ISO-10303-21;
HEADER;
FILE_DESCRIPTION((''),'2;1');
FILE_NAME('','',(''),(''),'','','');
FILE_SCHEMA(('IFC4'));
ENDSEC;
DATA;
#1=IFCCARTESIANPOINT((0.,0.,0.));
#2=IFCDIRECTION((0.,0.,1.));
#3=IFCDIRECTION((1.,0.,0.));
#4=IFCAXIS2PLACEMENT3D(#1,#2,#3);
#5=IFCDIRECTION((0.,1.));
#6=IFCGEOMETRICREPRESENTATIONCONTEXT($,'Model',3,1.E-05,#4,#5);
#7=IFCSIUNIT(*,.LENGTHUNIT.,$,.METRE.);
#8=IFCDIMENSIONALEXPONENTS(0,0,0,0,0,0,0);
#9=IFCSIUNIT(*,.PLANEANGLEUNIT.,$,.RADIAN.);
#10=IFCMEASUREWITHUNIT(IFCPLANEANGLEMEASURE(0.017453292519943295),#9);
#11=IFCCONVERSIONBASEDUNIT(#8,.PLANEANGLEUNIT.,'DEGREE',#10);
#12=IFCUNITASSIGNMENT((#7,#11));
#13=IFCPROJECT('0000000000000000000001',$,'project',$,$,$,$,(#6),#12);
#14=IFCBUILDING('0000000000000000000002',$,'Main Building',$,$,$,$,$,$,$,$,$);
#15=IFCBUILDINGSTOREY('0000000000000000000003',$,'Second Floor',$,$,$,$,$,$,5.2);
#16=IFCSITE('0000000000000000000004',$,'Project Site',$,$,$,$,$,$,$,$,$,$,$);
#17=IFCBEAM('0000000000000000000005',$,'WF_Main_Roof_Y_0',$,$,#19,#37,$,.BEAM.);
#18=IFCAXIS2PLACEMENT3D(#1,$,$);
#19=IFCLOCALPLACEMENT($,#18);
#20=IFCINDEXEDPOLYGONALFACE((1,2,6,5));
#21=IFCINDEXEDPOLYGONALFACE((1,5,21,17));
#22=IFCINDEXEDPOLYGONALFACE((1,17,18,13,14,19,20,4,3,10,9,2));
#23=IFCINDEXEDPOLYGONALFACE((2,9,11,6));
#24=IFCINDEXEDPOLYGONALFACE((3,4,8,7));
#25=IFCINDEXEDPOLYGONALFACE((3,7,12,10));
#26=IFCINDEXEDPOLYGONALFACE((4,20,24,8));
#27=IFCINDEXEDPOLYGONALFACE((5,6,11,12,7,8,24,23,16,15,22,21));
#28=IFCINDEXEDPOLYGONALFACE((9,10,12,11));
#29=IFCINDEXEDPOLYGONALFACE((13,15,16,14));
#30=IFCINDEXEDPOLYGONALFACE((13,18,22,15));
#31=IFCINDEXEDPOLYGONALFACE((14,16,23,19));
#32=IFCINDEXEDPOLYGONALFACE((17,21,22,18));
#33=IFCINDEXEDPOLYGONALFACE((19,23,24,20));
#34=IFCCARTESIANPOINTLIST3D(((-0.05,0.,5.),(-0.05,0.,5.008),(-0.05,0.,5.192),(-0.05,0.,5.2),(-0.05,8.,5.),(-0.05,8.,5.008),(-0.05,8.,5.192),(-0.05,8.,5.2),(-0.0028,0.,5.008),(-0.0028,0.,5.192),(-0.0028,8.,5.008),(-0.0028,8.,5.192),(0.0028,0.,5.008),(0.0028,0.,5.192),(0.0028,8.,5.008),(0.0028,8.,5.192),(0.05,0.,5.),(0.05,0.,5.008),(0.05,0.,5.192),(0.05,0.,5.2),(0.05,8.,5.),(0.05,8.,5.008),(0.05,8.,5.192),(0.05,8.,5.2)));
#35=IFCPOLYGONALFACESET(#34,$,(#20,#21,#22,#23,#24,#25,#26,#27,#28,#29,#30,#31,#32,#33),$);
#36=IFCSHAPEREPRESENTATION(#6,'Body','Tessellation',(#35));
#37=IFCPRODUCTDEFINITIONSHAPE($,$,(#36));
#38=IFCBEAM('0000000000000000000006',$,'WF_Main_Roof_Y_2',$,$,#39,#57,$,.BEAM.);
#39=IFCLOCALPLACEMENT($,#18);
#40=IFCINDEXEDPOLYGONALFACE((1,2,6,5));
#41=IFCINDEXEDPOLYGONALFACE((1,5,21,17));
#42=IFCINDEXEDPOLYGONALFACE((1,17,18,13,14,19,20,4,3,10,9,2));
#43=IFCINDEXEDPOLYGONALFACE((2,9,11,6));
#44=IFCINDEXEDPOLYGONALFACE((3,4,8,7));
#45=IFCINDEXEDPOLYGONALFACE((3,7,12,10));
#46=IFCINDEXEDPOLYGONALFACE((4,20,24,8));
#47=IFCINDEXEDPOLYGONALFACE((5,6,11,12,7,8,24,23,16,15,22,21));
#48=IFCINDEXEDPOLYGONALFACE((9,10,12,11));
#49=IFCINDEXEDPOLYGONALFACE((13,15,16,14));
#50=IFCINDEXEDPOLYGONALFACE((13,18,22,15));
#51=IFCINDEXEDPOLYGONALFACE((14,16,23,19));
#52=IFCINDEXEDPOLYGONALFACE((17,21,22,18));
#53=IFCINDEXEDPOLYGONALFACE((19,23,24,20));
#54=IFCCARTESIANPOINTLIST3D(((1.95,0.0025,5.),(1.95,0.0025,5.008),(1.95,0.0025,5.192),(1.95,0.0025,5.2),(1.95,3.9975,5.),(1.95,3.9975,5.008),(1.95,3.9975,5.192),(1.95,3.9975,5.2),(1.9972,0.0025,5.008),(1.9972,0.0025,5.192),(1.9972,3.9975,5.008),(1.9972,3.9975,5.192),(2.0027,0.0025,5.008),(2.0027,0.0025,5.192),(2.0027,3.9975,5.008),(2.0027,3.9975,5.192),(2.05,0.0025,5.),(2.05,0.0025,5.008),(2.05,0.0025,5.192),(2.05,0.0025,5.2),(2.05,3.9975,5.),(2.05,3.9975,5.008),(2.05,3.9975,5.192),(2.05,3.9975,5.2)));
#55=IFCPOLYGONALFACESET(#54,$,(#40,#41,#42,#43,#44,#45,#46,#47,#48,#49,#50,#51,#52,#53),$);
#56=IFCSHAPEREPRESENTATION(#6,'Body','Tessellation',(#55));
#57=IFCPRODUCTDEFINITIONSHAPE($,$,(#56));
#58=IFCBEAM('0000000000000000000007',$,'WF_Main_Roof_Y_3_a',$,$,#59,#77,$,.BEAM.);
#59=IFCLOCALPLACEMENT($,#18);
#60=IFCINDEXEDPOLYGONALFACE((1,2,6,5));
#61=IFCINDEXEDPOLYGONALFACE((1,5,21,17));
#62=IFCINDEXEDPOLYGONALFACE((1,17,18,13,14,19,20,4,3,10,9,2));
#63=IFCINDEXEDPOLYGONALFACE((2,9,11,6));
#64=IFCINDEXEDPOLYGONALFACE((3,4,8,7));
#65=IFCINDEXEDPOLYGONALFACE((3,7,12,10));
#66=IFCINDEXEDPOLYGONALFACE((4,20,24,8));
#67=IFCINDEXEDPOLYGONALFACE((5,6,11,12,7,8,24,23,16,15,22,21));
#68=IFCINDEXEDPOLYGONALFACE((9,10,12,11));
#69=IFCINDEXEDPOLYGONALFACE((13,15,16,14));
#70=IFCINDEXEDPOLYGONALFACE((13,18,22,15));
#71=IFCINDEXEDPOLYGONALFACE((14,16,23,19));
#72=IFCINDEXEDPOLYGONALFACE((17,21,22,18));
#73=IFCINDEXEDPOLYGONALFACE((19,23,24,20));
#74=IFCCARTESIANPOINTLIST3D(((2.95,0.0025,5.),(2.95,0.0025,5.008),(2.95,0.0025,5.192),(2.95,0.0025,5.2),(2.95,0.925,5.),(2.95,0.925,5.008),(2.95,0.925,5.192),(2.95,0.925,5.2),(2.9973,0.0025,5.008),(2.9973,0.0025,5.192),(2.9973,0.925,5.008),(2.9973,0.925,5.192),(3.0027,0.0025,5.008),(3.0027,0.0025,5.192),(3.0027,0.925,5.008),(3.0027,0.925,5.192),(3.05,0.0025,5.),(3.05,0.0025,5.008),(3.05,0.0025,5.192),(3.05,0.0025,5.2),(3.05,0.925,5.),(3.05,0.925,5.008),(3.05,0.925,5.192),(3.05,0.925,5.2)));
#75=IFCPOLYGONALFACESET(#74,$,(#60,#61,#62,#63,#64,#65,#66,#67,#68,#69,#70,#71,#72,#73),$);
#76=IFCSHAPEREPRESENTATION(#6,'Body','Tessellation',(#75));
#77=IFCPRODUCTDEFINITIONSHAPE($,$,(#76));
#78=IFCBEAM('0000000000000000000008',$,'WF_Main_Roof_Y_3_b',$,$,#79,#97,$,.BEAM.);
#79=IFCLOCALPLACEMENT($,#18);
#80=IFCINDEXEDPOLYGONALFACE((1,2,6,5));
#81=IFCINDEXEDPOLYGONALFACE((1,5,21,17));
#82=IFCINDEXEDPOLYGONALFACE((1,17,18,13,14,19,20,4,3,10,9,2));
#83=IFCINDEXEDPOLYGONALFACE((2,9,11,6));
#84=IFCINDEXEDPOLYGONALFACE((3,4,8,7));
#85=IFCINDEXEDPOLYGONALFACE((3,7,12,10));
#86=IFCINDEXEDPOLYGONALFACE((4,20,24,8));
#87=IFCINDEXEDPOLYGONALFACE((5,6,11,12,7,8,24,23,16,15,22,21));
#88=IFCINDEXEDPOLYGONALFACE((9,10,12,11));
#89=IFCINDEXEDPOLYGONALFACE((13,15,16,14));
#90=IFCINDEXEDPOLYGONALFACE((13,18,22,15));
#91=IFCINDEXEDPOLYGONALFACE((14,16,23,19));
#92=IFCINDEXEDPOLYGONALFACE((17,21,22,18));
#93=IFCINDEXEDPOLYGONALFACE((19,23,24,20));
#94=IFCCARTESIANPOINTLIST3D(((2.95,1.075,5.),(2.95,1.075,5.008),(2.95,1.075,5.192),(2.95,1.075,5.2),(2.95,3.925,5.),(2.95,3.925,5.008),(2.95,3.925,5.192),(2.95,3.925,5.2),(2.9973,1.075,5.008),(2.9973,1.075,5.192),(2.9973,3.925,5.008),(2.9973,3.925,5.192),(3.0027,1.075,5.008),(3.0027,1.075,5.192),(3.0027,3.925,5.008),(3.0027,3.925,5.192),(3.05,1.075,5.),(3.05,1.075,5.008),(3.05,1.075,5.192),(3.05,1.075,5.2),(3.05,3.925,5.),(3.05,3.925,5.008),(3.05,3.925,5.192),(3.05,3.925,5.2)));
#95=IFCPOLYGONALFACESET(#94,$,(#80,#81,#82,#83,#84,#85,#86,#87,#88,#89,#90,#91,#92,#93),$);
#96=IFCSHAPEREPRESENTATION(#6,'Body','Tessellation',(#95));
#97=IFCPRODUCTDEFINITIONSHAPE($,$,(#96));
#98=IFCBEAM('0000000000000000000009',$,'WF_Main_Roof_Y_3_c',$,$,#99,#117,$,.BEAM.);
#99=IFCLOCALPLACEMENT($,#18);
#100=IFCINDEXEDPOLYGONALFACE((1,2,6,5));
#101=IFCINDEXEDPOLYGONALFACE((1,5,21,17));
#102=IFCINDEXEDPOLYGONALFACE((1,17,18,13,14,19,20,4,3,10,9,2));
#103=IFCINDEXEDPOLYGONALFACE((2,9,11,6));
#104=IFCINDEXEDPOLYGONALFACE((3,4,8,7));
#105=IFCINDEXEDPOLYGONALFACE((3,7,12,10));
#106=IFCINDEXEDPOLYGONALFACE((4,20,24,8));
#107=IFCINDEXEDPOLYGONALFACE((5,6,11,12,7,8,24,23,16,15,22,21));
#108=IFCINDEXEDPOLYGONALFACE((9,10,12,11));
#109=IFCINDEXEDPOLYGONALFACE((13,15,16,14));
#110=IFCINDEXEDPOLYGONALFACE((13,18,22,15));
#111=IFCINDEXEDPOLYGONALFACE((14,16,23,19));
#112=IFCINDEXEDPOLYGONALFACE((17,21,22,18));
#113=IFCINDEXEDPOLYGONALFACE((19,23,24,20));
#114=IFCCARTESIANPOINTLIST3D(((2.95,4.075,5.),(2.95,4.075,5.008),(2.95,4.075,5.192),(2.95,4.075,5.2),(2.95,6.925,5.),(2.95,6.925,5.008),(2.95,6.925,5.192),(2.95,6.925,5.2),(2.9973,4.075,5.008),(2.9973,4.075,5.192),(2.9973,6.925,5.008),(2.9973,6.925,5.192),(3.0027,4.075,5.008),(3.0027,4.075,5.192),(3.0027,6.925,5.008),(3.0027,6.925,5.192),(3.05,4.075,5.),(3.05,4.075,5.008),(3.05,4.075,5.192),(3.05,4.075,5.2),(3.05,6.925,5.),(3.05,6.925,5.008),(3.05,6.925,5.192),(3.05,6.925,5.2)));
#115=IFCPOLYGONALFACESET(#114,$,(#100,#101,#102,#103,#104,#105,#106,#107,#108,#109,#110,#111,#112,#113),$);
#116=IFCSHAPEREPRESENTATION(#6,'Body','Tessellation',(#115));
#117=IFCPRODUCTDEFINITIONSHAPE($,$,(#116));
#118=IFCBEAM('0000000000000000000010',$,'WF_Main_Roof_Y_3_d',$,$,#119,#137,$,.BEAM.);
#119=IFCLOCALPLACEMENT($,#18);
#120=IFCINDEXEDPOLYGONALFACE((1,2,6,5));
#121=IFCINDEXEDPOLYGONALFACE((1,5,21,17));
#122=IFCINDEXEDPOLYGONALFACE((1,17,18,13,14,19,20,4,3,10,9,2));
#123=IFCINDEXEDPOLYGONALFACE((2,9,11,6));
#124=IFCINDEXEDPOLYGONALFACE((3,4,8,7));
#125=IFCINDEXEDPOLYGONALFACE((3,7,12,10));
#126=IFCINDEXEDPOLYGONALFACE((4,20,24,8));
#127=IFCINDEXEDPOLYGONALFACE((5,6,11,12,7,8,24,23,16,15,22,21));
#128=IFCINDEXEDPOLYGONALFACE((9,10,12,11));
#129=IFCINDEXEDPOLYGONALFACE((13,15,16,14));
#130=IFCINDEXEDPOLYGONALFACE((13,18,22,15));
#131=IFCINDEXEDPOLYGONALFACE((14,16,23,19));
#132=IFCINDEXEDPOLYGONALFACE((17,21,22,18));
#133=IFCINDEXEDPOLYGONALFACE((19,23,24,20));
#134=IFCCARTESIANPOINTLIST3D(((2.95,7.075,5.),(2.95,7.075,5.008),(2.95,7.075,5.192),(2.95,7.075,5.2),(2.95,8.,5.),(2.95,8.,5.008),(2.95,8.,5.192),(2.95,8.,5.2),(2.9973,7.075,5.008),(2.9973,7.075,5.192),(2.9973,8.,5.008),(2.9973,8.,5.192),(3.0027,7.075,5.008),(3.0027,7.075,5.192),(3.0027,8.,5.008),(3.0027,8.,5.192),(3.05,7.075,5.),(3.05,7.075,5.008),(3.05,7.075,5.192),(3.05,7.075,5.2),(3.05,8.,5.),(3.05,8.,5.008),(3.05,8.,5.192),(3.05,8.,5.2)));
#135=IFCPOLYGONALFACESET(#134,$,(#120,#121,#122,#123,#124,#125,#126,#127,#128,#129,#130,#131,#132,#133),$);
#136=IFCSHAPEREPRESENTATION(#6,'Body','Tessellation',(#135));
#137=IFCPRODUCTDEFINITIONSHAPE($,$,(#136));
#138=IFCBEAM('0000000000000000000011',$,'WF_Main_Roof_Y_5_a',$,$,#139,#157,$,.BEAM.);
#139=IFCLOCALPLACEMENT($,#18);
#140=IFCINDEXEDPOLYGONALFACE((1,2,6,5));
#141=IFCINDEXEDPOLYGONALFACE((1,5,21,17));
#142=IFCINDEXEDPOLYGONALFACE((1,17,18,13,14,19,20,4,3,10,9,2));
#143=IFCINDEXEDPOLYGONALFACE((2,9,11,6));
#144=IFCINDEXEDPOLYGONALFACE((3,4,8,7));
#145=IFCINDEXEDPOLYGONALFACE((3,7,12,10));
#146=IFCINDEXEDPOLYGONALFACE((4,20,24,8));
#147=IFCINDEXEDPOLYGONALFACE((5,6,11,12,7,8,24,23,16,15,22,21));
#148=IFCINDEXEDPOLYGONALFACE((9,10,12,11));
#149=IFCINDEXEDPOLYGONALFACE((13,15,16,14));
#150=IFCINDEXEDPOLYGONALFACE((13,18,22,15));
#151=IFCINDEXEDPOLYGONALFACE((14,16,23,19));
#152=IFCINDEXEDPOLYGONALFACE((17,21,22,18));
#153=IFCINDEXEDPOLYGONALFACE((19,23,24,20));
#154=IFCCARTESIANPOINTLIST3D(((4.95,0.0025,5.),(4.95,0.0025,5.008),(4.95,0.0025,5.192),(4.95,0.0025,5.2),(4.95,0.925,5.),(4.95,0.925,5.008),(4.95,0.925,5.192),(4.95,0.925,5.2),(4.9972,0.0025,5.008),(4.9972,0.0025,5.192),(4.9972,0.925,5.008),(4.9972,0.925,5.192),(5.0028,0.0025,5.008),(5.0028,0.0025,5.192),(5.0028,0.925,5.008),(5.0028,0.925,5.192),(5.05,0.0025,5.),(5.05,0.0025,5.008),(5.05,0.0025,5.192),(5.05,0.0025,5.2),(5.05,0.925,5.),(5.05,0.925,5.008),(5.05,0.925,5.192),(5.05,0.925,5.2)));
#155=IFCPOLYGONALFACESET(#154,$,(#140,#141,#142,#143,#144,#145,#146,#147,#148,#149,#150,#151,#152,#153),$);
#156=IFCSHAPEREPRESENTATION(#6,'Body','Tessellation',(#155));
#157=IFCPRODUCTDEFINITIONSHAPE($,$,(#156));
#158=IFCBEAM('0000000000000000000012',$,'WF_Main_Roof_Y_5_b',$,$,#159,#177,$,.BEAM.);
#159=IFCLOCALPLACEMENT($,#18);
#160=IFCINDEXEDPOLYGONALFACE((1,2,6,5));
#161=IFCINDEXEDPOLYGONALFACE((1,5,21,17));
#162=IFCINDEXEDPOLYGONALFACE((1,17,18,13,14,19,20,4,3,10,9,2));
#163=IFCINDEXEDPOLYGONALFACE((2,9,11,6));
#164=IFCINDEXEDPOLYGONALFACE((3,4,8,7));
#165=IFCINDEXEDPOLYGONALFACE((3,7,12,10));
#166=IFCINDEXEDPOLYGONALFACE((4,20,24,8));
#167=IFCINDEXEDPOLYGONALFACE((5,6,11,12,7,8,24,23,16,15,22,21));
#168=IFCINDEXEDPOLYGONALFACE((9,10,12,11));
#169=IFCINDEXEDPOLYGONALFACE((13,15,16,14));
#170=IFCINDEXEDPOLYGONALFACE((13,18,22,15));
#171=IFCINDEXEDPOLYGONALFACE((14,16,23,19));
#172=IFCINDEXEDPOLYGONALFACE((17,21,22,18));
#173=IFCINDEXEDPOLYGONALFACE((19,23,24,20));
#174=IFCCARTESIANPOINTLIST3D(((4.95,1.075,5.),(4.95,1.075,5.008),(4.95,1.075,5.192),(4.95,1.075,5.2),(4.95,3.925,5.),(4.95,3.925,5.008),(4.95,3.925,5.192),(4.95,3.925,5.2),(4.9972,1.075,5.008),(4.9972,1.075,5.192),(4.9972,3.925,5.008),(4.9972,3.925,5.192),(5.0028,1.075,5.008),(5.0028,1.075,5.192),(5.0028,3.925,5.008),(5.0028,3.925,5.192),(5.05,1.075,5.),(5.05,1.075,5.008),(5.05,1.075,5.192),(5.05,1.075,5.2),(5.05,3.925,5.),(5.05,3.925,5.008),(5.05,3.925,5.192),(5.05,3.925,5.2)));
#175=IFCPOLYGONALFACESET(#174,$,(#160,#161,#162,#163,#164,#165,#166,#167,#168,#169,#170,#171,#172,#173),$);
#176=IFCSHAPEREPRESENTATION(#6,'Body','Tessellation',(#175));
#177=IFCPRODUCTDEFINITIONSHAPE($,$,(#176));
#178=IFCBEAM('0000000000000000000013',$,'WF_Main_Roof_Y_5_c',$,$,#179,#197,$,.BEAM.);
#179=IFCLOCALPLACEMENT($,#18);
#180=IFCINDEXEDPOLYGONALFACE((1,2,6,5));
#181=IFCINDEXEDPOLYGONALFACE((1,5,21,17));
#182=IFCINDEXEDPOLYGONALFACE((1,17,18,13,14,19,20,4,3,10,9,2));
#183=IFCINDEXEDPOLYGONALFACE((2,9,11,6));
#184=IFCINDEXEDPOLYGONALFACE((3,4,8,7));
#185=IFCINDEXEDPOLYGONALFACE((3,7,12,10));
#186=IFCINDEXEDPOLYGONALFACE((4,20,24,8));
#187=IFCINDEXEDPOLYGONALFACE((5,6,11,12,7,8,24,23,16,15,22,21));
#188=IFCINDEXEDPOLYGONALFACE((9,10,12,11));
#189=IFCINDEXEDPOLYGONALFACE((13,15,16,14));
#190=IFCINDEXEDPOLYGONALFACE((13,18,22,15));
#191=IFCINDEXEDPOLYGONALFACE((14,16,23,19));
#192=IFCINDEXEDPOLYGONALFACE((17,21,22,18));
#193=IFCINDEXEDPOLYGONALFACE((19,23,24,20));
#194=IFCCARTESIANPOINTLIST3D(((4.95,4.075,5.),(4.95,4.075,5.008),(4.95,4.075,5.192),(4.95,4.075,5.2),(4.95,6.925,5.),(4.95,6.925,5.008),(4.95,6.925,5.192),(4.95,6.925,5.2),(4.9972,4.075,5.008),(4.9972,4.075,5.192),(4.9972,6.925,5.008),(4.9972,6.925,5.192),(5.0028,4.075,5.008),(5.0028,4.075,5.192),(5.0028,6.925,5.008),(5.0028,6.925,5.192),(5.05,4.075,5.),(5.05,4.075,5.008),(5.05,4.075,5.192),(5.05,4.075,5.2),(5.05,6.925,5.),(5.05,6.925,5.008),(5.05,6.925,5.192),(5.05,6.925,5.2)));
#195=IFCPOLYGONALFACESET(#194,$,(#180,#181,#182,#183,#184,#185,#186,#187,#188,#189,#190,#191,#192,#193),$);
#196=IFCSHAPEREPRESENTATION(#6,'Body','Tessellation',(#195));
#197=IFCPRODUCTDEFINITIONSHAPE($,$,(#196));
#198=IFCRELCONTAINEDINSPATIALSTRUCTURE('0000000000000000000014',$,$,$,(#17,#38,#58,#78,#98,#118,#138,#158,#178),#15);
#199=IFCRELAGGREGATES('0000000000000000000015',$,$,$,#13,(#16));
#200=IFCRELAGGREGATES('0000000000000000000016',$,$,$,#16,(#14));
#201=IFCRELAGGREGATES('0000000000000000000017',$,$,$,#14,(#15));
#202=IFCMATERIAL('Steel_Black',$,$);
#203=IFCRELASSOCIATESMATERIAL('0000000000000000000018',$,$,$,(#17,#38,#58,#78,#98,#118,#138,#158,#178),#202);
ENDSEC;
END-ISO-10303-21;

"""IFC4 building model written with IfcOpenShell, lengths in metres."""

from ifc_helpers import new_model, entity, si_unit, converted_unit, direction, frame, frame_2d, origin_with_axes, place, context, project, spatial, i_section, extrude, material, element, save


model = new_model("IFC4")

# Units and contexts
model_context = context("Model", 3, precision=1e-05, world=origin_with_axes(), true_north=direction((0.0, 1.0)))
ifc_project = project(units=[si_unit("LENGTHUNIT", "METRE"), converted_unit("PLANEANGLEUNIT", "DEGREE", entity("IfcPlaneAngleMeasure", 0.017453292519943295), si_unit("PLANEANGLEUNIT", "RADIAN"), dimensions=[0, 0, 0, 0, 0, 0, 0])], contexts=[model_context])

# Site, building, storey
site = spatial("IfcSite", under=ifc_project, Name="Project Site")
building = spatial("IfcBuilding", under=site, Name="Main Building")
storey = spatial("IfcBuildingStorey", under=building, Name="Second Floor", Elevation=5.2)

# Beams
ifc_material = material(Name="Steel_Black")
beam_1_placement = place(None, frame((0.0, 0.0, 5.0), z_axis=(0.0, 0.0, 1.0), x_axis=(0.0, 1.0, 0.0)))
element("IfcBeam", 1, at=beam_1_placement, inside=storey, material=ifc_material, Name="WF_Main_Roof_Y_0", PredefinedType="BEAM", context=model_context, shape_type="SweptSolid", body=[
    extrude(i_section(OverallWidth=0.1, OverallDepth=0.2, WebThickness=0.0055, FlangeThickness=0.008, at=frame_2d((0.0, 0.1))), frame((0.0, 0.0, 0.0), z_axis=(1.0, 0.0, 0.0), x_axis=(0.0, 1.0, 0.0)), (0.0, 0.0, 1.0), 8.0),
])
beam_2_placement = place(None, frame((2.0, 0.0025, 5.0), z_axis=(0.0, 0.0, 1.0), x_axis=(0.0, 1.0, 0.0)))
element("IfcBeam", 2, at=beam_2_placement, inside=storey, material=ifc_material, Name="WF_Main_Roof_Y_2", PredefinedType="BEAM", context=model_context, shape_type="SweptSolid", body=[
    extrude(i_section(OverallWidth=0.1, OverallDepth=0.2, WebThickness=0.0055, FlangeThickness=0.008, at=frame_2d((0.0, 0.1))), frame((0.0, 0.0, 0.0), z_axis=(1.0, 0.0, 0.0), x_axis=(0.0, 1.0, 0.0)), (0.0, 0.0, 1.0), 3.995),
])
beam_3_placement = place(None, frame((3.0, 0.0025, 5.0), z_axis=(0.0, 0.0, 1.0), x_axis=(0.0, 1.0, 0.0)))
element("IfcBeam", 3, at=beam_3_placement, inside=storey, material=ifc_material, Name="WF_Main_Roof_Y_3_a", PredefinedType="BEAM", context=model_context, shape_type="SweptSolid", body=[
    extrude(i_section(OverallWidth=0.1, OverallDepth=0.2, WebThickness=0.0055, FlangeThickness=0.008, at=frame_2d((0.0, 0.1))), frame((0.0, 0.0, 0.0), z_axis=(1.0, 0.0, 0.0), x_axis=(0.0, 1.0, 0.0)), (0.0, 0.0, 1.0), 0.9225),
])
for number, where, z_axis, x_axis, name in (
    (4, (3.0, 1.075, 5.0), (0.0, 0.0, 1.0), (0.0, 1.0, 0.0), "WF_Main_Roof_Y_3_b"),
    (5, (3.0, 4.075, 5.0), (0.0, 0.0, 1.0), (0.0, 1.0, 0.0), "WF_Main_Roof_Y_3_c"),
):
    element("IfcBeam", number, at=place(None, frame(where, z_axis=z_axis, x_axis=x_axis)), inside=storey, material=ifc_material, Name=name, PredefinedType="BEAM", context=model_context, shape_type="SweptSolid", body=[
        extrude(i_section(OverallWidth=0.1, OverallDepth=0.2, WebThickness=0.0055, FlangeThickness=0.008, at=frame_2d((0.0, 0.1))), frame((0.0, 0.0, 0.0), z_axis=(1.0, 0.0, 0.0), x_axis=(0.0, 1.0, 0.0)), (0.0, 0.0, 1.0), 2.85),
    ])
beam_4_placement = place(None, frame((3.0, 7.075, 5.0), z_axis=(0.0, 0.0, 1.0), x_axis=(0.0, 1.0, 0.0)))
element("IfcBeam", 6, at=beam_4_placement, inside=storey, material=ifc_material, Name="WF_Main_Roof_Y_3_d", PredefinedType="BEAM", context=model_context, shape_type="SweptSolid", body=[
    extrude(i_section(OverallWidth=0.1, OverallDepth=0.2, WebThickness=0.0055, FlangeThickness=0.008, at=frame_2d((0.0, 0.1))), frame((0.0, 0.0, 0.0), z_axis=(1.0, 0.0, 0.0), x_axis=(0.0, 1.0, 0.0)), (0.0, 0.0, 1.0), 0.925),
])
beam_5_placement = place(None, frame((5.0, 0.0025, 5.0), z_axis=(0.0, 0.0, 1.0), x_axis=(0.0, 1.0, 0.0)))
element("IfcBeam", 7, at=beam_5_placement, inside=storey, material=ifc_material, Name="WF_Main_Roof_Y_5_a", PredefinedType="BEAM", context=model_context, shape_type="SweptSolid", body=[
    extrude(i_section(OverallWidth=0.1, OverallDepth=0.2, WebThickness=0.0055, FlangeThickness=0.008, at=frame_2d((0.0, 0.1))), frame((0.0, 0.0, 0.0), z_axis=(1.0, 0.0, 0.0), x_axis=(0.0, 1.0, 0.0)), (0.0, 0.0, 1.0), 0.9225),
])
for number, where, z_axis, x_axis, name in (
    (8, (5.0, 1.075, 5.0), (0.0, 0.0, 1.0), (0.0, 1.0, 0.0), "WF_Main_Roof_Y_5_b"),
    (9, (5.0, 4.075, 5.0), (0.0, 0.0, 1.0), (0.0, 1.0, 0.0), "WF_Main_Roof_Y_5_c"),
):
    element("IfcBeam", number, at=place(None, frame(where, z_axis=z_axis, x_axis=x_axis)), inside=storey, material=ifc_material, Name=name, PredefinedType="BEAM", context=model_context, shape_type="SweptSolid", body=[
        extrude(i_section(OverallWidth=0.1, OverallDepth=0.2, WebThickness=0.0055, FlangeThickness=0.008, at=frame_2d((0.0, 0.1))), frame((0.0, 0.0, 0.0), z_axis=(1.0, 0.0, 0.0), x_axis=(0.0, 1.0, 0.0)), (0.0, 0.0, 1.0), 2.85),
    ])

save(model, "model.ifc")
